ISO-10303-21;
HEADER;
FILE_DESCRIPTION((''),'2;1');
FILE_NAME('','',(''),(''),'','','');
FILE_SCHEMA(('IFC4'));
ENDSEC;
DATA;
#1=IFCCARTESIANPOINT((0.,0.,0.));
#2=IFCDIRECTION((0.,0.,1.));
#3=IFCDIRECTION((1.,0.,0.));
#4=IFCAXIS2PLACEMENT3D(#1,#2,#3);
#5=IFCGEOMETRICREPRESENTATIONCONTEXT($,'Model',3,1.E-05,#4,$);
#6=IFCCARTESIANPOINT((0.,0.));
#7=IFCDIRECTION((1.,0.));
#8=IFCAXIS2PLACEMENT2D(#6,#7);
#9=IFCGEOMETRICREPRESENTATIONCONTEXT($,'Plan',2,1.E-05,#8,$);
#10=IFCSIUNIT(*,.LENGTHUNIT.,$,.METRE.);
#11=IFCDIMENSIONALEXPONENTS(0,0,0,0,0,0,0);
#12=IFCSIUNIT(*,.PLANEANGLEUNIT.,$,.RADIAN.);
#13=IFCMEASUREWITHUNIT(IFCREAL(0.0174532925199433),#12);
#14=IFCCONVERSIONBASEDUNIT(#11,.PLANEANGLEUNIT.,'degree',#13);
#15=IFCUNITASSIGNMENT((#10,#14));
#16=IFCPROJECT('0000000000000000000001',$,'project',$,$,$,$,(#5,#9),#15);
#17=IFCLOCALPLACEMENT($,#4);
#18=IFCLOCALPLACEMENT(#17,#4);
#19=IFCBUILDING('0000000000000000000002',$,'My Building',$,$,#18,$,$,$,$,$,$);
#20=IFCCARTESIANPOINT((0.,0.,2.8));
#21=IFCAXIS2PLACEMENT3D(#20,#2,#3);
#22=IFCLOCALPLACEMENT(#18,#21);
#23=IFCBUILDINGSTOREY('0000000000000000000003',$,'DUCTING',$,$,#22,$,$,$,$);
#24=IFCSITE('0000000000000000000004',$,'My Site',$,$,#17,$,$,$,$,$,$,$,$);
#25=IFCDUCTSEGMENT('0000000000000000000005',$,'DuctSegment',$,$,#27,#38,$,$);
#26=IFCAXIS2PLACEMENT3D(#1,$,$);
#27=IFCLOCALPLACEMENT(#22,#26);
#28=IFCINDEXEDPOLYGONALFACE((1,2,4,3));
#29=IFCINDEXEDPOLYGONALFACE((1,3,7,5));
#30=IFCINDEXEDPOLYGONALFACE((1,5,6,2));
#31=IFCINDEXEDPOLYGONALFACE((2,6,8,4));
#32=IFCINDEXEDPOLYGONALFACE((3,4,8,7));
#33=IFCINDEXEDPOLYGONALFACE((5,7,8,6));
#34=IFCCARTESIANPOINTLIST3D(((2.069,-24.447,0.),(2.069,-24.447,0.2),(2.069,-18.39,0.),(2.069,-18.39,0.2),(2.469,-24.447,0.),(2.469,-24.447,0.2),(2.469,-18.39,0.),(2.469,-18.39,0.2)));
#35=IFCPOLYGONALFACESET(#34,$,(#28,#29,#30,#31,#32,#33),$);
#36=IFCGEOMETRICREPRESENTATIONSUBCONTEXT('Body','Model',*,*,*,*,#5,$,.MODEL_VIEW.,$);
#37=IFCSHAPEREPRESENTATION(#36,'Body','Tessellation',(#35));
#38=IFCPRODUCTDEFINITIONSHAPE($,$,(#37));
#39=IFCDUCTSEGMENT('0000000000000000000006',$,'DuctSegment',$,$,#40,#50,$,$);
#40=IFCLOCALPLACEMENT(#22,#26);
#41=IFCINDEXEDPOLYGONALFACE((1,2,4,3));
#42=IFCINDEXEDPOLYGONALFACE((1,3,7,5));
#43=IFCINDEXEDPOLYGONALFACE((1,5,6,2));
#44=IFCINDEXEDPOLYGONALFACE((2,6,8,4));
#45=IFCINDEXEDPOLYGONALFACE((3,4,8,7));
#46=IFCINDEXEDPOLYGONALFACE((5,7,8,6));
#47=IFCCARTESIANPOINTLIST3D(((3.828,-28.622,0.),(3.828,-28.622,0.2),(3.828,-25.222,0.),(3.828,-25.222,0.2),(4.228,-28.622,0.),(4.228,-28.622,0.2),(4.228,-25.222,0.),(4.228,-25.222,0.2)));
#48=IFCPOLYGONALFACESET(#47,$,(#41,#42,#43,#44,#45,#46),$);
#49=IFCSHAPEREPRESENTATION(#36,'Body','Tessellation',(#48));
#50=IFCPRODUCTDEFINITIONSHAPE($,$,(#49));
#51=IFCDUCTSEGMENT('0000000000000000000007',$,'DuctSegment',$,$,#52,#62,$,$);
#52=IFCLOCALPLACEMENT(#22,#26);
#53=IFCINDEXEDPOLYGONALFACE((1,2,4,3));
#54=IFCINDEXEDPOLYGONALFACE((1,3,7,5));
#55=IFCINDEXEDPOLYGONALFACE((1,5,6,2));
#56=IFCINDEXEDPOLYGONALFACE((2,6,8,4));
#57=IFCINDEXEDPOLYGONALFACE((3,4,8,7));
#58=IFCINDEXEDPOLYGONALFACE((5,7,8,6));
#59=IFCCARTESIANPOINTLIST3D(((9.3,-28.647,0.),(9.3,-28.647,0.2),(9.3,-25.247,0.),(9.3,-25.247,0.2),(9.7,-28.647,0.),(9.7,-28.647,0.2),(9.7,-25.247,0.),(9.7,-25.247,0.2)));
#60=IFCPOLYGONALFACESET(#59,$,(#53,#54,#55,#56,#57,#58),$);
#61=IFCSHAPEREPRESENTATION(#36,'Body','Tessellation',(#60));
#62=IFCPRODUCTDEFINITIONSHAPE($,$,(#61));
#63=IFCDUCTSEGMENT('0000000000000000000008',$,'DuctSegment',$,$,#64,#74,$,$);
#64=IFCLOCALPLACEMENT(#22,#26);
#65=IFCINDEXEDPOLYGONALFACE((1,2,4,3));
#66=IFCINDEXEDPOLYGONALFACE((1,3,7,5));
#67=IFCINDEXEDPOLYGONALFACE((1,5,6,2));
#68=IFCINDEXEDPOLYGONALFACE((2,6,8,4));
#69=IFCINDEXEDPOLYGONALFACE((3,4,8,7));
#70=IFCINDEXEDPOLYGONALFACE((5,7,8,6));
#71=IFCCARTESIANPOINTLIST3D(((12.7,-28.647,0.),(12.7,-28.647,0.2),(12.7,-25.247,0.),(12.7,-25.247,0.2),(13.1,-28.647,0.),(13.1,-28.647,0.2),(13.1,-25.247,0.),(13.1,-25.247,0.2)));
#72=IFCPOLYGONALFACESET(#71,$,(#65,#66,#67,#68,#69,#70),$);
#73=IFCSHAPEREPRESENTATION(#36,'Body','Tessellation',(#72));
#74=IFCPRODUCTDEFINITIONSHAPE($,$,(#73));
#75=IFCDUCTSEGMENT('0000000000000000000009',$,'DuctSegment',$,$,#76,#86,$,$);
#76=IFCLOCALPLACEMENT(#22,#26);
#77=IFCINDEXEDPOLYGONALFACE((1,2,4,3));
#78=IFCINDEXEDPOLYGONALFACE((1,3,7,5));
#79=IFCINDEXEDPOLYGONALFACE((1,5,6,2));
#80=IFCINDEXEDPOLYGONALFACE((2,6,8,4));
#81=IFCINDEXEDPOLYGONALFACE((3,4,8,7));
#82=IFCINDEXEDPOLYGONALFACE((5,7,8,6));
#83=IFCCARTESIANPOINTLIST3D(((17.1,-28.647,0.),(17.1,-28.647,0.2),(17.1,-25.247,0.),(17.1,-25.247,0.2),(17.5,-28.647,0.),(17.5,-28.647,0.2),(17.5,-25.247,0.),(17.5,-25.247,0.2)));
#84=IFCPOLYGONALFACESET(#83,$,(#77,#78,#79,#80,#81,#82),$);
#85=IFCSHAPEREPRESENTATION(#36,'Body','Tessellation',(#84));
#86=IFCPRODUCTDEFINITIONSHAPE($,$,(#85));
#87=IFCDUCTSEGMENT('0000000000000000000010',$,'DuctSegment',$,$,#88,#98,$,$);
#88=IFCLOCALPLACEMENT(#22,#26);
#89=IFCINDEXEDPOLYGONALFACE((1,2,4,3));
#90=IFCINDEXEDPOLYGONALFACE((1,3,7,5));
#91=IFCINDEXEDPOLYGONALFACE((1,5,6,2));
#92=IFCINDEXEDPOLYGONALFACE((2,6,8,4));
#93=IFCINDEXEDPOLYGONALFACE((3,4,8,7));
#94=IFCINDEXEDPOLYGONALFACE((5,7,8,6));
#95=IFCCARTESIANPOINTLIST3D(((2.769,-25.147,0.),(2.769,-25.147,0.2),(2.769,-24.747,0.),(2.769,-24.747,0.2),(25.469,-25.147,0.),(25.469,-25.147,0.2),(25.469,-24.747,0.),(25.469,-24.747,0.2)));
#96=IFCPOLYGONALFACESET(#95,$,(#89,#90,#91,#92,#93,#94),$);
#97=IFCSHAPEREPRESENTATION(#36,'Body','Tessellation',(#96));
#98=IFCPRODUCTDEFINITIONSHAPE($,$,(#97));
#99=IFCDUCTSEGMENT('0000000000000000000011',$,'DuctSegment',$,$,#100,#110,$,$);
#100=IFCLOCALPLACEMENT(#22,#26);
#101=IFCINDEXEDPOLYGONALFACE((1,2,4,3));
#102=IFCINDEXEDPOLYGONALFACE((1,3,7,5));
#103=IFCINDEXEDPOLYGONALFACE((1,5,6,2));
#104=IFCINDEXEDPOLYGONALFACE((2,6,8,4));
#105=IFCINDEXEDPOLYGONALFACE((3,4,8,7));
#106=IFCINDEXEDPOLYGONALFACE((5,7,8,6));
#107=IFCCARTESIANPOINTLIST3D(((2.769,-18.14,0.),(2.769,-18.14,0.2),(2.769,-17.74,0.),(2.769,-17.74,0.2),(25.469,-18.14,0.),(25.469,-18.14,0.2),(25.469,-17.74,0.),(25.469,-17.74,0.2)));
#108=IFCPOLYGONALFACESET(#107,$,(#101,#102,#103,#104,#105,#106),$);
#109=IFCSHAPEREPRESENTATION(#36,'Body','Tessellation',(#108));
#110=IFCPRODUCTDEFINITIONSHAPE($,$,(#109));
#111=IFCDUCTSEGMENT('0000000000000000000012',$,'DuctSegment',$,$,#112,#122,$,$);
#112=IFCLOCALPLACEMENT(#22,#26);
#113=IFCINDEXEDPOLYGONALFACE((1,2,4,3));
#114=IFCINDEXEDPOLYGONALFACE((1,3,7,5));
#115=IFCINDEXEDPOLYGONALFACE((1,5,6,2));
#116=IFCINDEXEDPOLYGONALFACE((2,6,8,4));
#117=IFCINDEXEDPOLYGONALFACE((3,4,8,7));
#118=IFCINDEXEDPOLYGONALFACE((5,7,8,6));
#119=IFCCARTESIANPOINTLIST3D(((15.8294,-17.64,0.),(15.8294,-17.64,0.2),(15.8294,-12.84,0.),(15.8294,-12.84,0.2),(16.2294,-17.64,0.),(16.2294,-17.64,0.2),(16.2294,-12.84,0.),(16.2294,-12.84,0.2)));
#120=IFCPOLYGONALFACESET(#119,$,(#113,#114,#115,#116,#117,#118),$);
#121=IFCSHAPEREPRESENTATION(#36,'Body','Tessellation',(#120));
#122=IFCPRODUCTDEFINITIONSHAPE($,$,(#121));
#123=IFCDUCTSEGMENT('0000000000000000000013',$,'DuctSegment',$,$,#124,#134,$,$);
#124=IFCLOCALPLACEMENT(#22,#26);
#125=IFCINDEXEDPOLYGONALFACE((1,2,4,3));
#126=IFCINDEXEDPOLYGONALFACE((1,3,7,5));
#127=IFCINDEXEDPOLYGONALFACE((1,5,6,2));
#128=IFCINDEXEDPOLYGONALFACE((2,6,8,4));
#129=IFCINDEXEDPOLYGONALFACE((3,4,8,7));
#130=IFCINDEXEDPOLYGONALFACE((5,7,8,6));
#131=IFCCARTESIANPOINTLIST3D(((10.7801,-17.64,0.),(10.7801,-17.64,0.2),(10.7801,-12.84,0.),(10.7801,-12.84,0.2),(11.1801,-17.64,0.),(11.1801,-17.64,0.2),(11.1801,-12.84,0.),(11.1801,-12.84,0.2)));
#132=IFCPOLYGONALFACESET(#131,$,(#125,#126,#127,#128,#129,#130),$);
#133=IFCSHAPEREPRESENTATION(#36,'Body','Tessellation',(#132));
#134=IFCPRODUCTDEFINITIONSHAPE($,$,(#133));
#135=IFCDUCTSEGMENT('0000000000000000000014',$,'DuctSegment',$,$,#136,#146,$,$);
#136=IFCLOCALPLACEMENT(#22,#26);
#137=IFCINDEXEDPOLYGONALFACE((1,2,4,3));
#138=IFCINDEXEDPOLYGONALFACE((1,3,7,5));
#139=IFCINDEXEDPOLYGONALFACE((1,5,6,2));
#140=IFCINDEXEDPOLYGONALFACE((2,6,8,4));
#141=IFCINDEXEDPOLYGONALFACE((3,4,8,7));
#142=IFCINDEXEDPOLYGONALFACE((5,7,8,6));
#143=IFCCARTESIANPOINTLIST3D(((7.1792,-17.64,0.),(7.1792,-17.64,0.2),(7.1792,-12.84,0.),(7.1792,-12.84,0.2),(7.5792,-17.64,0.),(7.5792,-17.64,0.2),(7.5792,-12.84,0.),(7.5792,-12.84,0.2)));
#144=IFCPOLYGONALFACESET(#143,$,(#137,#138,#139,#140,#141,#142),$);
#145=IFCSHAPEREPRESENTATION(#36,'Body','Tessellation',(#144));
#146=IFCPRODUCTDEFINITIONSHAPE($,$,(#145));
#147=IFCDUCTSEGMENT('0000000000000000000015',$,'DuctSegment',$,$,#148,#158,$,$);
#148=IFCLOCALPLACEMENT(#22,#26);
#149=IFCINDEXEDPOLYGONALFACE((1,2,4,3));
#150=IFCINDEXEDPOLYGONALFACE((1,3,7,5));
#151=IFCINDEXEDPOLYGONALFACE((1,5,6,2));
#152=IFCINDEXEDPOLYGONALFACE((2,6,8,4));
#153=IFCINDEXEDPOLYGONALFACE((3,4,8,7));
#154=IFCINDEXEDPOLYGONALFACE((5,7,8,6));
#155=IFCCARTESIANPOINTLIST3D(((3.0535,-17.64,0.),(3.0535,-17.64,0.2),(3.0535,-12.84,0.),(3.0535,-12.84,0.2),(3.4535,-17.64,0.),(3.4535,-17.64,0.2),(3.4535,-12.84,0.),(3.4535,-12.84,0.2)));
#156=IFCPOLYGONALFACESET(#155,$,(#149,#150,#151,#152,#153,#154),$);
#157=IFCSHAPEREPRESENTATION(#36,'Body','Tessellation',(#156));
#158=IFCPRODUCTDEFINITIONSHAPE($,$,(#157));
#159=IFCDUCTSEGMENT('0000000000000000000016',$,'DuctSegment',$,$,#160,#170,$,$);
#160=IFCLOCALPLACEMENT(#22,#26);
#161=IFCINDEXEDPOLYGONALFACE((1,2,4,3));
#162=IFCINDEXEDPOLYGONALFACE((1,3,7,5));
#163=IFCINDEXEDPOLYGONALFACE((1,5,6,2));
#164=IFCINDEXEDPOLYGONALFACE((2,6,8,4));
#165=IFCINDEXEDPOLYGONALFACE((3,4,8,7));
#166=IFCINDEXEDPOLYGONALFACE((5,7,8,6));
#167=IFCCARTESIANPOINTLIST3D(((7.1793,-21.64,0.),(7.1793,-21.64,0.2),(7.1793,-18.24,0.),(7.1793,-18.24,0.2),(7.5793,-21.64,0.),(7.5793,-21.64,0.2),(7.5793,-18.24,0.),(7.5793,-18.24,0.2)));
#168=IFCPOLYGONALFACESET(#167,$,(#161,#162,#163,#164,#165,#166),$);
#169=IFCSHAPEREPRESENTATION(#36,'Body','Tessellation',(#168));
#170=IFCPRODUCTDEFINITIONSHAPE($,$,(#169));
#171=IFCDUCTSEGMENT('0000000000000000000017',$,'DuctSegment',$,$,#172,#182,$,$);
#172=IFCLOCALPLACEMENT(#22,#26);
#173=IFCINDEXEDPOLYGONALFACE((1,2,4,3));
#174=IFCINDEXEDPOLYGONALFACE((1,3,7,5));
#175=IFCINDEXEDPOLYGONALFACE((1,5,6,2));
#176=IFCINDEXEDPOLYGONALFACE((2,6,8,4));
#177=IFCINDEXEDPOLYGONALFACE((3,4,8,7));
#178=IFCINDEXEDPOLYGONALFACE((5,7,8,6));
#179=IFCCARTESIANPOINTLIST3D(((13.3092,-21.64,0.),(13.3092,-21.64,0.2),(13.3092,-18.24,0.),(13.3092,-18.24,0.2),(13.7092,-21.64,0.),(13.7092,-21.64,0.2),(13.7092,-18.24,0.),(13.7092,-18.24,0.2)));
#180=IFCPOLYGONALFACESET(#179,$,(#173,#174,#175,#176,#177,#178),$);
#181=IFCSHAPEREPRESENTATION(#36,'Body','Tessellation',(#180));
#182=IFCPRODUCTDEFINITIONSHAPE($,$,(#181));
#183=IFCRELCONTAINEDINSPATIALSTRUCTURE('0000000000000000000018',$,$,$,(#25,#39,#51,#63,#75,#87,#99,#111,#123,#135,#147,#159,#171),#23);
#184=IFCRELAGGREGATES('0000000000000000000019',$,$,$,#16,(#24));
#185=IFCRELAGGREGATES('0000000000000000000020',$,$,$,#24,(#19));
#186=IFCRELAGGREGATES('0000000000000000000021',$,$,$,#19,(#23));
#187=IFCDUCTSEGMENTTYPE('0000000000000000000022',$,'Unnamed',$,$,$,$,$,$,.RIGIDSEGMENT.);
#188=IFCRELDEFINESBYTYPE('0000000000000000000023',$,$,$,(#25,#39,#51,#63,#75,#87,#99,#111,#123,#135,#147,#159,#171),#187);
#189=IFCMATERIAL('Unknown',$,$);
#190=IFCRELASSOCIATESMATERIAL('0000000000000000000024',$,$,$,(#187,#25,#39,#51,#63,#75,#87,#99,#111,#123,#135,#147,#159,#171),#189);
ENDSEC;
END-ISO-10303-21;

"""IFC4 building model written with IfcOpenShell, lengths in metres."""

from ifc_helpers import new_model, entity, si_unit, converted_unit, frame, origin_with_axes, origin_2d_with_axis, place, context, subcontext, project, spatial, rectangle, extrude, material, material_profile, profile_set, profile_usage, type_object, element, save


model = new_model("IFC4")

# Units and contexts
model_context = context("Model", 3, precision=1e-05, world=origin_with_axes())
plan_context = context("Plan", 2, precision=1e-05, world=origin_2d_with_axis())
body_context = subcontext(model_context, "Body", "Model", "MODEL_VIEW")
ifc_project = project(units=[si_unit("LENGTHUNIT", "METRE"), converted_unit("PLANEANGLEUNIT", "degree", entity("IfcReal", 0.0174532925199433), si_unit("PLANEANGLEUNIT", "RADIAN"), dimensions=[0, 0, 0, 0, 0, 0, 0])], contexts=[model_context, plan_context])

# Site, building, storey
site_placement = place(None, origin_with_axes())
site = spatial("IfcSite", under=ifc_project, at=site_placement, Name="My Site")
building_placement = place(site_placement, origin_with_axes())
building = spatial("IfcBuilding", under=site, at=building_placement, Name="My Building")
storey_placement = place(building_placement, frame((0.0, 0.0, 2.8), z_axis=(0.0, 0.0, 1.0), x_axis=(1.0, 0.0, 0.0)))
storey = spatial("IfcBuildingStorey", under=building, at=storey_placement, Name="DUCTING")

# Duct segments
ifc_material = material(Name="Unknown")
ifc_material_profile_1 = material_profile(ifc_material, rectangle(XDim=0.4, YDim=0.2))
ifc_profile_set_1 = profile_set([ifc_material_profile_1])
ifc_profile_usage_1 = profile_usage(ifc_profile_set_1, cardinal=5)
duct_segment_type = type_object("IfcDuctSegmentType", Name="Unnamed", PredefinedType="RIGIDSEGMENT", material=ifc_profile_set_1)
duct_segment_1_placement = place(storey_placement, frame((2.269, -18.39, 0.1), z_axis=(0.0, -1.0, 0.0), x_axis=(1.0, 0.0, 0.0)))
element("IfcDuctSegment", 1, at=duct_segment_1_placement, inside=storey, type_object=duct_segment_type, material=ifc_profile_usage_1, Name="DuctSegment", context=body_context, shape_type="SweptSolid", body=[
    extrude(rectangle(XDim=0.4, YDim=0.2), origin_with_axes(), (0.0, 0.0, 1.0), 6.057),
])
ifc_profile_usage_2 = profile_usage(ifc_profile_set_1, cardinal=5)
duct_segment_2_placement = place(storey_placement, frame((4.028, -25.222, 0.1), z_axis=(0.0, -1.0, -0.000004), x_axis=(1.0, 0.0, 0.0)))
element("IfcDuctSegment", 2, at=duct_segment_2_placement, inside=storey, type_object=duct_segment_type, material=ifc_profile_usage_2, Name="DuctSegment", context=body_context, shape_type="SweptSolid", body=[
    extrude(rectangle(XDim=0.4, YDim=0.2), origin_with_axes(), (0.0, 0.0, 1.0), 3.4),
])
ifc_profile_usage_3 = profile_usage(ifc_profile_set_1, cardinal=5)
duct_segment_3_placement = place(storey_placement, frame((9.5, -25.247, 0.1), z_axis=(0.0, -1.0, -0.000004), x_axis=(1.0, 0.0, 0.0)))
element("IfcDuctSegment", 3, at=duct_segment_3_placement, inside=storey, type_object=duct_segment_type, material=ifc_profile_usage_3, Name="DuctSegment", context=body_context, shape_type="SweptSolid", body=[
    extrude(rectangle(XDim=0.4, YDim=0.2), origin_with_axes(), (0.0, 0.0, 1.0), 3.4),
])
ifc_profile_usage_4 = profile_usage(ifc_profile_set_1, cardinal=5)
duct_segment_4_placement = place(storey_placement, frame((12.9, -25.247, 0.1), z_axis=(0.0, -1.0, -0.000004), x_axis=(1.0, 0.0, 0.0)))
element("IfcDuctSegment", 4, at=duct_segment_4_placement, inside=storey, type_object=duct_segment_type, material=ifc_profile_usage_4, Name="DuctSegment", context=body_context, shape_type="SweptSolid", body=[
    extrude(rectangle(XDim=0.4, YDim=0.2), origin_with_axes(), (0.0, 0.0, 1.0), 3.4),
])
ifc_profile_usage_5 = profile_usage(ifc_profile_set_1, cardinal=5)
duct_segment_5_placement = place(storey_placement, frame((17.3, -25.247, 0.1), z_axis=(0.0, -1.0, -0.000004), x_axis=(1.0, 0.0, 0.0)))
element("IfcDuctSegment", 5, at=duct_segment_5_placement, inside=storey, type_object=duct_segment_type, material=ifc_profile_usage_5, Name="DuctSegment", context=body_context, shape_type="SweptSolid", body=[
    extrude(rectangle(XDim=0.4, YDim=0.2), origin_with_axes(), (0.0, 0.0, 1.0), 3.4),
])
ifc_profile_usage_6 = profile_usage(ifc_profile_set_1, cardinal=5)
duct_segment_6_placement = place(storey_placement, frame((2.769, -24.947, 0.1), z_axis=(1.0, 0.0, 0.0), x_axis=(0.0, 1.0, 0.0)))
element("IfcDuctSegment", 6, at=duct_segment_6_placement, inside=storey, type_object=duct_segment_type, material=ifc_profile_usage_6, Name="DuctSegment", context=body_context, shape_type="SweptSolid", body=[
    extrude(rectangle(XDim=0.4, YDim=0.2), origin_with_axes(), (0.0, 0.0, 1.0), 22.7),
])
ifc_profile_usage_7 = profile_usage(ifc_profile_set_1, cardinal=5)
duct_segment_7_placement = place(storey_placement, frame((2.769, -17.94, 0.1), z_axis=(1.0, 0.0, 0.0), x_axis=(0.0, 1.0, 0.0)))
element("IfcDuctSegment", 7, at=duct_segment_7_placement, inside=storey, type_object=duct_segment_type, material=ifc_profile_usage_7, Name="DuctSegment", context=body_context, shape_type="SweptSolid", body=[
    extrude(rectangle(XDim=0.4, YDim=0.2), origin_with_axes(), (0.0, 0.0, 1.0), 22.7),
])
ifc_profile_usage_8 = profile_usage(ifc_profile_set_1, cardinal=5)
duct_segment_8_placement = place(storey_placement, frame((16.0294, -17.64, 0.1), z_axis=(0.0, 1.0, 0.0), x_axis=(-1.0, 0.0, 0.0)))
element("IfcDuctSegment", 8, at=duct_segment_8_placement, inside=storey, type_object=duct_segment_type, material=ifc_profile_usage_8, Name="DuctSegment", context=body_context, shape_type="SweptSolid", body=[
    extrude(rectangle(XDim=0.4, YDim=0.2), origin_with_axes(), (0.0, 0.0, 1.0), 4.8),
])
ifc_profile_usage_9 = profile_usage(ifc_profile_set_1, cardinal=5)
duct_segment_9_placement = place(storey_placement, frame((10.9801, -17.64, 0.1), z_axis=(0.0, 1.0, 0.0), x_axis=(-1.0, 0.0, 0.0)))
element("IfcDuctSegment", 9, at=duct_segment_9_placement, inside=storey, type_object=duct_segment_type, material=ifc_profile_usage_9, Name="DuctSegment", context=body_context, shape_type="SweptSolid", body=[
    extrude(rectangle(XDim=0.4, YDim=0.2), origin_with_axes(), (0.0, 0.0, 1.0), 4.8),
])
ifc_profile_usage_10 = profile_usage(ifc_profile_set_1, cardinal=5)
duct_segment_10_placement = place(storey_placement, frame((7.3792, -17.64, 0.1), z_axis=(0.0, 1.0, 0.0), x_axis=(-1.0, 0.0, 0.0)))
element("IfcDuctSegment", 10, at=duct_segment_10_placement, inside=storey, type_object=duct_segment_type, material=ifc_profile_usage_10, Name="DuctSegment", context=body_context, shape_type="SweptSolid", body=[
    extrude(rectangle(XDim=0.4, YDim=0.2), origin_with_axes(), (0.0, 0.0, 1.0), 4.8),
])
ifc_profile_usage_11 = profile_usage(ifc_profile_set_1, cardinal=5)
duct_segment_11_placement = place(storey_placement, frame((3.2535, -17.64, 0.1), z_axis=(0.0, 1.0, 0.0), x_axis=(-1.0, 0.0, 0.0)))
element("IfcDuctSegment", 11, at=duct_segment_11_placement, inside=storey, type_object=duct_segment_type, material=ifc_profile_usage_11, Name="DuctSegment", context=body_context, shape_type="SweptSolid", body=[
    extrude(rectangle(XDim=0.4, YDim=0.2), origin_with_axes(), (0.0, 0.0, 1.0), 4.8),
])
ifc_profile_usage_12 = profile_usage(ifc_profile_set_1, cardinal=5)
duct_segment_12_placement = place(storey_placement, frame((7.3793, -18.24, 0.1), z_axis=(0.0, -1.0, -0.000004), x_axis=(1.0, 0.0, 0.0)))
element("IfcDuctSegment", 12, at=duct_segment_12_placement, inside=storey, type_object=duct_segment_type, material=ifc_profile_usage_12, Name="DuctSegment", context=body_context, shape_type="SweptSolid", body=[
    extrude(rectangle(XDim=0.4, YDim=0.2), origin_with_axes(), (0.0, 0.0, 1.0), 3.4),
])
ifc_profile_usage_13 = profile_usage(ifc_profile_set_1, cardinal=5)
duct_segment_13_placement = place(storey_placement, frame((13.5092, -18.24, 0.1), z_axis=(0.0, -1.0, -0.000004), x_axis=(1.0, 0.0, 0.0)))
element("IfcDuctSegment", 13, at=duct_segment_13_placement, inside=storey, type_object=duct_segment_type, material=ifc_profile_usage_13, Name="DuctSegment", context=body_context, shape_type="SweptSolid", body=[
    extrude(rectangle(XDim=0.4, YDim=0.2), origin_with_axes(), (0.0, 0.0, 1.0), 3.4),
])

save(model, "model.ifc")
